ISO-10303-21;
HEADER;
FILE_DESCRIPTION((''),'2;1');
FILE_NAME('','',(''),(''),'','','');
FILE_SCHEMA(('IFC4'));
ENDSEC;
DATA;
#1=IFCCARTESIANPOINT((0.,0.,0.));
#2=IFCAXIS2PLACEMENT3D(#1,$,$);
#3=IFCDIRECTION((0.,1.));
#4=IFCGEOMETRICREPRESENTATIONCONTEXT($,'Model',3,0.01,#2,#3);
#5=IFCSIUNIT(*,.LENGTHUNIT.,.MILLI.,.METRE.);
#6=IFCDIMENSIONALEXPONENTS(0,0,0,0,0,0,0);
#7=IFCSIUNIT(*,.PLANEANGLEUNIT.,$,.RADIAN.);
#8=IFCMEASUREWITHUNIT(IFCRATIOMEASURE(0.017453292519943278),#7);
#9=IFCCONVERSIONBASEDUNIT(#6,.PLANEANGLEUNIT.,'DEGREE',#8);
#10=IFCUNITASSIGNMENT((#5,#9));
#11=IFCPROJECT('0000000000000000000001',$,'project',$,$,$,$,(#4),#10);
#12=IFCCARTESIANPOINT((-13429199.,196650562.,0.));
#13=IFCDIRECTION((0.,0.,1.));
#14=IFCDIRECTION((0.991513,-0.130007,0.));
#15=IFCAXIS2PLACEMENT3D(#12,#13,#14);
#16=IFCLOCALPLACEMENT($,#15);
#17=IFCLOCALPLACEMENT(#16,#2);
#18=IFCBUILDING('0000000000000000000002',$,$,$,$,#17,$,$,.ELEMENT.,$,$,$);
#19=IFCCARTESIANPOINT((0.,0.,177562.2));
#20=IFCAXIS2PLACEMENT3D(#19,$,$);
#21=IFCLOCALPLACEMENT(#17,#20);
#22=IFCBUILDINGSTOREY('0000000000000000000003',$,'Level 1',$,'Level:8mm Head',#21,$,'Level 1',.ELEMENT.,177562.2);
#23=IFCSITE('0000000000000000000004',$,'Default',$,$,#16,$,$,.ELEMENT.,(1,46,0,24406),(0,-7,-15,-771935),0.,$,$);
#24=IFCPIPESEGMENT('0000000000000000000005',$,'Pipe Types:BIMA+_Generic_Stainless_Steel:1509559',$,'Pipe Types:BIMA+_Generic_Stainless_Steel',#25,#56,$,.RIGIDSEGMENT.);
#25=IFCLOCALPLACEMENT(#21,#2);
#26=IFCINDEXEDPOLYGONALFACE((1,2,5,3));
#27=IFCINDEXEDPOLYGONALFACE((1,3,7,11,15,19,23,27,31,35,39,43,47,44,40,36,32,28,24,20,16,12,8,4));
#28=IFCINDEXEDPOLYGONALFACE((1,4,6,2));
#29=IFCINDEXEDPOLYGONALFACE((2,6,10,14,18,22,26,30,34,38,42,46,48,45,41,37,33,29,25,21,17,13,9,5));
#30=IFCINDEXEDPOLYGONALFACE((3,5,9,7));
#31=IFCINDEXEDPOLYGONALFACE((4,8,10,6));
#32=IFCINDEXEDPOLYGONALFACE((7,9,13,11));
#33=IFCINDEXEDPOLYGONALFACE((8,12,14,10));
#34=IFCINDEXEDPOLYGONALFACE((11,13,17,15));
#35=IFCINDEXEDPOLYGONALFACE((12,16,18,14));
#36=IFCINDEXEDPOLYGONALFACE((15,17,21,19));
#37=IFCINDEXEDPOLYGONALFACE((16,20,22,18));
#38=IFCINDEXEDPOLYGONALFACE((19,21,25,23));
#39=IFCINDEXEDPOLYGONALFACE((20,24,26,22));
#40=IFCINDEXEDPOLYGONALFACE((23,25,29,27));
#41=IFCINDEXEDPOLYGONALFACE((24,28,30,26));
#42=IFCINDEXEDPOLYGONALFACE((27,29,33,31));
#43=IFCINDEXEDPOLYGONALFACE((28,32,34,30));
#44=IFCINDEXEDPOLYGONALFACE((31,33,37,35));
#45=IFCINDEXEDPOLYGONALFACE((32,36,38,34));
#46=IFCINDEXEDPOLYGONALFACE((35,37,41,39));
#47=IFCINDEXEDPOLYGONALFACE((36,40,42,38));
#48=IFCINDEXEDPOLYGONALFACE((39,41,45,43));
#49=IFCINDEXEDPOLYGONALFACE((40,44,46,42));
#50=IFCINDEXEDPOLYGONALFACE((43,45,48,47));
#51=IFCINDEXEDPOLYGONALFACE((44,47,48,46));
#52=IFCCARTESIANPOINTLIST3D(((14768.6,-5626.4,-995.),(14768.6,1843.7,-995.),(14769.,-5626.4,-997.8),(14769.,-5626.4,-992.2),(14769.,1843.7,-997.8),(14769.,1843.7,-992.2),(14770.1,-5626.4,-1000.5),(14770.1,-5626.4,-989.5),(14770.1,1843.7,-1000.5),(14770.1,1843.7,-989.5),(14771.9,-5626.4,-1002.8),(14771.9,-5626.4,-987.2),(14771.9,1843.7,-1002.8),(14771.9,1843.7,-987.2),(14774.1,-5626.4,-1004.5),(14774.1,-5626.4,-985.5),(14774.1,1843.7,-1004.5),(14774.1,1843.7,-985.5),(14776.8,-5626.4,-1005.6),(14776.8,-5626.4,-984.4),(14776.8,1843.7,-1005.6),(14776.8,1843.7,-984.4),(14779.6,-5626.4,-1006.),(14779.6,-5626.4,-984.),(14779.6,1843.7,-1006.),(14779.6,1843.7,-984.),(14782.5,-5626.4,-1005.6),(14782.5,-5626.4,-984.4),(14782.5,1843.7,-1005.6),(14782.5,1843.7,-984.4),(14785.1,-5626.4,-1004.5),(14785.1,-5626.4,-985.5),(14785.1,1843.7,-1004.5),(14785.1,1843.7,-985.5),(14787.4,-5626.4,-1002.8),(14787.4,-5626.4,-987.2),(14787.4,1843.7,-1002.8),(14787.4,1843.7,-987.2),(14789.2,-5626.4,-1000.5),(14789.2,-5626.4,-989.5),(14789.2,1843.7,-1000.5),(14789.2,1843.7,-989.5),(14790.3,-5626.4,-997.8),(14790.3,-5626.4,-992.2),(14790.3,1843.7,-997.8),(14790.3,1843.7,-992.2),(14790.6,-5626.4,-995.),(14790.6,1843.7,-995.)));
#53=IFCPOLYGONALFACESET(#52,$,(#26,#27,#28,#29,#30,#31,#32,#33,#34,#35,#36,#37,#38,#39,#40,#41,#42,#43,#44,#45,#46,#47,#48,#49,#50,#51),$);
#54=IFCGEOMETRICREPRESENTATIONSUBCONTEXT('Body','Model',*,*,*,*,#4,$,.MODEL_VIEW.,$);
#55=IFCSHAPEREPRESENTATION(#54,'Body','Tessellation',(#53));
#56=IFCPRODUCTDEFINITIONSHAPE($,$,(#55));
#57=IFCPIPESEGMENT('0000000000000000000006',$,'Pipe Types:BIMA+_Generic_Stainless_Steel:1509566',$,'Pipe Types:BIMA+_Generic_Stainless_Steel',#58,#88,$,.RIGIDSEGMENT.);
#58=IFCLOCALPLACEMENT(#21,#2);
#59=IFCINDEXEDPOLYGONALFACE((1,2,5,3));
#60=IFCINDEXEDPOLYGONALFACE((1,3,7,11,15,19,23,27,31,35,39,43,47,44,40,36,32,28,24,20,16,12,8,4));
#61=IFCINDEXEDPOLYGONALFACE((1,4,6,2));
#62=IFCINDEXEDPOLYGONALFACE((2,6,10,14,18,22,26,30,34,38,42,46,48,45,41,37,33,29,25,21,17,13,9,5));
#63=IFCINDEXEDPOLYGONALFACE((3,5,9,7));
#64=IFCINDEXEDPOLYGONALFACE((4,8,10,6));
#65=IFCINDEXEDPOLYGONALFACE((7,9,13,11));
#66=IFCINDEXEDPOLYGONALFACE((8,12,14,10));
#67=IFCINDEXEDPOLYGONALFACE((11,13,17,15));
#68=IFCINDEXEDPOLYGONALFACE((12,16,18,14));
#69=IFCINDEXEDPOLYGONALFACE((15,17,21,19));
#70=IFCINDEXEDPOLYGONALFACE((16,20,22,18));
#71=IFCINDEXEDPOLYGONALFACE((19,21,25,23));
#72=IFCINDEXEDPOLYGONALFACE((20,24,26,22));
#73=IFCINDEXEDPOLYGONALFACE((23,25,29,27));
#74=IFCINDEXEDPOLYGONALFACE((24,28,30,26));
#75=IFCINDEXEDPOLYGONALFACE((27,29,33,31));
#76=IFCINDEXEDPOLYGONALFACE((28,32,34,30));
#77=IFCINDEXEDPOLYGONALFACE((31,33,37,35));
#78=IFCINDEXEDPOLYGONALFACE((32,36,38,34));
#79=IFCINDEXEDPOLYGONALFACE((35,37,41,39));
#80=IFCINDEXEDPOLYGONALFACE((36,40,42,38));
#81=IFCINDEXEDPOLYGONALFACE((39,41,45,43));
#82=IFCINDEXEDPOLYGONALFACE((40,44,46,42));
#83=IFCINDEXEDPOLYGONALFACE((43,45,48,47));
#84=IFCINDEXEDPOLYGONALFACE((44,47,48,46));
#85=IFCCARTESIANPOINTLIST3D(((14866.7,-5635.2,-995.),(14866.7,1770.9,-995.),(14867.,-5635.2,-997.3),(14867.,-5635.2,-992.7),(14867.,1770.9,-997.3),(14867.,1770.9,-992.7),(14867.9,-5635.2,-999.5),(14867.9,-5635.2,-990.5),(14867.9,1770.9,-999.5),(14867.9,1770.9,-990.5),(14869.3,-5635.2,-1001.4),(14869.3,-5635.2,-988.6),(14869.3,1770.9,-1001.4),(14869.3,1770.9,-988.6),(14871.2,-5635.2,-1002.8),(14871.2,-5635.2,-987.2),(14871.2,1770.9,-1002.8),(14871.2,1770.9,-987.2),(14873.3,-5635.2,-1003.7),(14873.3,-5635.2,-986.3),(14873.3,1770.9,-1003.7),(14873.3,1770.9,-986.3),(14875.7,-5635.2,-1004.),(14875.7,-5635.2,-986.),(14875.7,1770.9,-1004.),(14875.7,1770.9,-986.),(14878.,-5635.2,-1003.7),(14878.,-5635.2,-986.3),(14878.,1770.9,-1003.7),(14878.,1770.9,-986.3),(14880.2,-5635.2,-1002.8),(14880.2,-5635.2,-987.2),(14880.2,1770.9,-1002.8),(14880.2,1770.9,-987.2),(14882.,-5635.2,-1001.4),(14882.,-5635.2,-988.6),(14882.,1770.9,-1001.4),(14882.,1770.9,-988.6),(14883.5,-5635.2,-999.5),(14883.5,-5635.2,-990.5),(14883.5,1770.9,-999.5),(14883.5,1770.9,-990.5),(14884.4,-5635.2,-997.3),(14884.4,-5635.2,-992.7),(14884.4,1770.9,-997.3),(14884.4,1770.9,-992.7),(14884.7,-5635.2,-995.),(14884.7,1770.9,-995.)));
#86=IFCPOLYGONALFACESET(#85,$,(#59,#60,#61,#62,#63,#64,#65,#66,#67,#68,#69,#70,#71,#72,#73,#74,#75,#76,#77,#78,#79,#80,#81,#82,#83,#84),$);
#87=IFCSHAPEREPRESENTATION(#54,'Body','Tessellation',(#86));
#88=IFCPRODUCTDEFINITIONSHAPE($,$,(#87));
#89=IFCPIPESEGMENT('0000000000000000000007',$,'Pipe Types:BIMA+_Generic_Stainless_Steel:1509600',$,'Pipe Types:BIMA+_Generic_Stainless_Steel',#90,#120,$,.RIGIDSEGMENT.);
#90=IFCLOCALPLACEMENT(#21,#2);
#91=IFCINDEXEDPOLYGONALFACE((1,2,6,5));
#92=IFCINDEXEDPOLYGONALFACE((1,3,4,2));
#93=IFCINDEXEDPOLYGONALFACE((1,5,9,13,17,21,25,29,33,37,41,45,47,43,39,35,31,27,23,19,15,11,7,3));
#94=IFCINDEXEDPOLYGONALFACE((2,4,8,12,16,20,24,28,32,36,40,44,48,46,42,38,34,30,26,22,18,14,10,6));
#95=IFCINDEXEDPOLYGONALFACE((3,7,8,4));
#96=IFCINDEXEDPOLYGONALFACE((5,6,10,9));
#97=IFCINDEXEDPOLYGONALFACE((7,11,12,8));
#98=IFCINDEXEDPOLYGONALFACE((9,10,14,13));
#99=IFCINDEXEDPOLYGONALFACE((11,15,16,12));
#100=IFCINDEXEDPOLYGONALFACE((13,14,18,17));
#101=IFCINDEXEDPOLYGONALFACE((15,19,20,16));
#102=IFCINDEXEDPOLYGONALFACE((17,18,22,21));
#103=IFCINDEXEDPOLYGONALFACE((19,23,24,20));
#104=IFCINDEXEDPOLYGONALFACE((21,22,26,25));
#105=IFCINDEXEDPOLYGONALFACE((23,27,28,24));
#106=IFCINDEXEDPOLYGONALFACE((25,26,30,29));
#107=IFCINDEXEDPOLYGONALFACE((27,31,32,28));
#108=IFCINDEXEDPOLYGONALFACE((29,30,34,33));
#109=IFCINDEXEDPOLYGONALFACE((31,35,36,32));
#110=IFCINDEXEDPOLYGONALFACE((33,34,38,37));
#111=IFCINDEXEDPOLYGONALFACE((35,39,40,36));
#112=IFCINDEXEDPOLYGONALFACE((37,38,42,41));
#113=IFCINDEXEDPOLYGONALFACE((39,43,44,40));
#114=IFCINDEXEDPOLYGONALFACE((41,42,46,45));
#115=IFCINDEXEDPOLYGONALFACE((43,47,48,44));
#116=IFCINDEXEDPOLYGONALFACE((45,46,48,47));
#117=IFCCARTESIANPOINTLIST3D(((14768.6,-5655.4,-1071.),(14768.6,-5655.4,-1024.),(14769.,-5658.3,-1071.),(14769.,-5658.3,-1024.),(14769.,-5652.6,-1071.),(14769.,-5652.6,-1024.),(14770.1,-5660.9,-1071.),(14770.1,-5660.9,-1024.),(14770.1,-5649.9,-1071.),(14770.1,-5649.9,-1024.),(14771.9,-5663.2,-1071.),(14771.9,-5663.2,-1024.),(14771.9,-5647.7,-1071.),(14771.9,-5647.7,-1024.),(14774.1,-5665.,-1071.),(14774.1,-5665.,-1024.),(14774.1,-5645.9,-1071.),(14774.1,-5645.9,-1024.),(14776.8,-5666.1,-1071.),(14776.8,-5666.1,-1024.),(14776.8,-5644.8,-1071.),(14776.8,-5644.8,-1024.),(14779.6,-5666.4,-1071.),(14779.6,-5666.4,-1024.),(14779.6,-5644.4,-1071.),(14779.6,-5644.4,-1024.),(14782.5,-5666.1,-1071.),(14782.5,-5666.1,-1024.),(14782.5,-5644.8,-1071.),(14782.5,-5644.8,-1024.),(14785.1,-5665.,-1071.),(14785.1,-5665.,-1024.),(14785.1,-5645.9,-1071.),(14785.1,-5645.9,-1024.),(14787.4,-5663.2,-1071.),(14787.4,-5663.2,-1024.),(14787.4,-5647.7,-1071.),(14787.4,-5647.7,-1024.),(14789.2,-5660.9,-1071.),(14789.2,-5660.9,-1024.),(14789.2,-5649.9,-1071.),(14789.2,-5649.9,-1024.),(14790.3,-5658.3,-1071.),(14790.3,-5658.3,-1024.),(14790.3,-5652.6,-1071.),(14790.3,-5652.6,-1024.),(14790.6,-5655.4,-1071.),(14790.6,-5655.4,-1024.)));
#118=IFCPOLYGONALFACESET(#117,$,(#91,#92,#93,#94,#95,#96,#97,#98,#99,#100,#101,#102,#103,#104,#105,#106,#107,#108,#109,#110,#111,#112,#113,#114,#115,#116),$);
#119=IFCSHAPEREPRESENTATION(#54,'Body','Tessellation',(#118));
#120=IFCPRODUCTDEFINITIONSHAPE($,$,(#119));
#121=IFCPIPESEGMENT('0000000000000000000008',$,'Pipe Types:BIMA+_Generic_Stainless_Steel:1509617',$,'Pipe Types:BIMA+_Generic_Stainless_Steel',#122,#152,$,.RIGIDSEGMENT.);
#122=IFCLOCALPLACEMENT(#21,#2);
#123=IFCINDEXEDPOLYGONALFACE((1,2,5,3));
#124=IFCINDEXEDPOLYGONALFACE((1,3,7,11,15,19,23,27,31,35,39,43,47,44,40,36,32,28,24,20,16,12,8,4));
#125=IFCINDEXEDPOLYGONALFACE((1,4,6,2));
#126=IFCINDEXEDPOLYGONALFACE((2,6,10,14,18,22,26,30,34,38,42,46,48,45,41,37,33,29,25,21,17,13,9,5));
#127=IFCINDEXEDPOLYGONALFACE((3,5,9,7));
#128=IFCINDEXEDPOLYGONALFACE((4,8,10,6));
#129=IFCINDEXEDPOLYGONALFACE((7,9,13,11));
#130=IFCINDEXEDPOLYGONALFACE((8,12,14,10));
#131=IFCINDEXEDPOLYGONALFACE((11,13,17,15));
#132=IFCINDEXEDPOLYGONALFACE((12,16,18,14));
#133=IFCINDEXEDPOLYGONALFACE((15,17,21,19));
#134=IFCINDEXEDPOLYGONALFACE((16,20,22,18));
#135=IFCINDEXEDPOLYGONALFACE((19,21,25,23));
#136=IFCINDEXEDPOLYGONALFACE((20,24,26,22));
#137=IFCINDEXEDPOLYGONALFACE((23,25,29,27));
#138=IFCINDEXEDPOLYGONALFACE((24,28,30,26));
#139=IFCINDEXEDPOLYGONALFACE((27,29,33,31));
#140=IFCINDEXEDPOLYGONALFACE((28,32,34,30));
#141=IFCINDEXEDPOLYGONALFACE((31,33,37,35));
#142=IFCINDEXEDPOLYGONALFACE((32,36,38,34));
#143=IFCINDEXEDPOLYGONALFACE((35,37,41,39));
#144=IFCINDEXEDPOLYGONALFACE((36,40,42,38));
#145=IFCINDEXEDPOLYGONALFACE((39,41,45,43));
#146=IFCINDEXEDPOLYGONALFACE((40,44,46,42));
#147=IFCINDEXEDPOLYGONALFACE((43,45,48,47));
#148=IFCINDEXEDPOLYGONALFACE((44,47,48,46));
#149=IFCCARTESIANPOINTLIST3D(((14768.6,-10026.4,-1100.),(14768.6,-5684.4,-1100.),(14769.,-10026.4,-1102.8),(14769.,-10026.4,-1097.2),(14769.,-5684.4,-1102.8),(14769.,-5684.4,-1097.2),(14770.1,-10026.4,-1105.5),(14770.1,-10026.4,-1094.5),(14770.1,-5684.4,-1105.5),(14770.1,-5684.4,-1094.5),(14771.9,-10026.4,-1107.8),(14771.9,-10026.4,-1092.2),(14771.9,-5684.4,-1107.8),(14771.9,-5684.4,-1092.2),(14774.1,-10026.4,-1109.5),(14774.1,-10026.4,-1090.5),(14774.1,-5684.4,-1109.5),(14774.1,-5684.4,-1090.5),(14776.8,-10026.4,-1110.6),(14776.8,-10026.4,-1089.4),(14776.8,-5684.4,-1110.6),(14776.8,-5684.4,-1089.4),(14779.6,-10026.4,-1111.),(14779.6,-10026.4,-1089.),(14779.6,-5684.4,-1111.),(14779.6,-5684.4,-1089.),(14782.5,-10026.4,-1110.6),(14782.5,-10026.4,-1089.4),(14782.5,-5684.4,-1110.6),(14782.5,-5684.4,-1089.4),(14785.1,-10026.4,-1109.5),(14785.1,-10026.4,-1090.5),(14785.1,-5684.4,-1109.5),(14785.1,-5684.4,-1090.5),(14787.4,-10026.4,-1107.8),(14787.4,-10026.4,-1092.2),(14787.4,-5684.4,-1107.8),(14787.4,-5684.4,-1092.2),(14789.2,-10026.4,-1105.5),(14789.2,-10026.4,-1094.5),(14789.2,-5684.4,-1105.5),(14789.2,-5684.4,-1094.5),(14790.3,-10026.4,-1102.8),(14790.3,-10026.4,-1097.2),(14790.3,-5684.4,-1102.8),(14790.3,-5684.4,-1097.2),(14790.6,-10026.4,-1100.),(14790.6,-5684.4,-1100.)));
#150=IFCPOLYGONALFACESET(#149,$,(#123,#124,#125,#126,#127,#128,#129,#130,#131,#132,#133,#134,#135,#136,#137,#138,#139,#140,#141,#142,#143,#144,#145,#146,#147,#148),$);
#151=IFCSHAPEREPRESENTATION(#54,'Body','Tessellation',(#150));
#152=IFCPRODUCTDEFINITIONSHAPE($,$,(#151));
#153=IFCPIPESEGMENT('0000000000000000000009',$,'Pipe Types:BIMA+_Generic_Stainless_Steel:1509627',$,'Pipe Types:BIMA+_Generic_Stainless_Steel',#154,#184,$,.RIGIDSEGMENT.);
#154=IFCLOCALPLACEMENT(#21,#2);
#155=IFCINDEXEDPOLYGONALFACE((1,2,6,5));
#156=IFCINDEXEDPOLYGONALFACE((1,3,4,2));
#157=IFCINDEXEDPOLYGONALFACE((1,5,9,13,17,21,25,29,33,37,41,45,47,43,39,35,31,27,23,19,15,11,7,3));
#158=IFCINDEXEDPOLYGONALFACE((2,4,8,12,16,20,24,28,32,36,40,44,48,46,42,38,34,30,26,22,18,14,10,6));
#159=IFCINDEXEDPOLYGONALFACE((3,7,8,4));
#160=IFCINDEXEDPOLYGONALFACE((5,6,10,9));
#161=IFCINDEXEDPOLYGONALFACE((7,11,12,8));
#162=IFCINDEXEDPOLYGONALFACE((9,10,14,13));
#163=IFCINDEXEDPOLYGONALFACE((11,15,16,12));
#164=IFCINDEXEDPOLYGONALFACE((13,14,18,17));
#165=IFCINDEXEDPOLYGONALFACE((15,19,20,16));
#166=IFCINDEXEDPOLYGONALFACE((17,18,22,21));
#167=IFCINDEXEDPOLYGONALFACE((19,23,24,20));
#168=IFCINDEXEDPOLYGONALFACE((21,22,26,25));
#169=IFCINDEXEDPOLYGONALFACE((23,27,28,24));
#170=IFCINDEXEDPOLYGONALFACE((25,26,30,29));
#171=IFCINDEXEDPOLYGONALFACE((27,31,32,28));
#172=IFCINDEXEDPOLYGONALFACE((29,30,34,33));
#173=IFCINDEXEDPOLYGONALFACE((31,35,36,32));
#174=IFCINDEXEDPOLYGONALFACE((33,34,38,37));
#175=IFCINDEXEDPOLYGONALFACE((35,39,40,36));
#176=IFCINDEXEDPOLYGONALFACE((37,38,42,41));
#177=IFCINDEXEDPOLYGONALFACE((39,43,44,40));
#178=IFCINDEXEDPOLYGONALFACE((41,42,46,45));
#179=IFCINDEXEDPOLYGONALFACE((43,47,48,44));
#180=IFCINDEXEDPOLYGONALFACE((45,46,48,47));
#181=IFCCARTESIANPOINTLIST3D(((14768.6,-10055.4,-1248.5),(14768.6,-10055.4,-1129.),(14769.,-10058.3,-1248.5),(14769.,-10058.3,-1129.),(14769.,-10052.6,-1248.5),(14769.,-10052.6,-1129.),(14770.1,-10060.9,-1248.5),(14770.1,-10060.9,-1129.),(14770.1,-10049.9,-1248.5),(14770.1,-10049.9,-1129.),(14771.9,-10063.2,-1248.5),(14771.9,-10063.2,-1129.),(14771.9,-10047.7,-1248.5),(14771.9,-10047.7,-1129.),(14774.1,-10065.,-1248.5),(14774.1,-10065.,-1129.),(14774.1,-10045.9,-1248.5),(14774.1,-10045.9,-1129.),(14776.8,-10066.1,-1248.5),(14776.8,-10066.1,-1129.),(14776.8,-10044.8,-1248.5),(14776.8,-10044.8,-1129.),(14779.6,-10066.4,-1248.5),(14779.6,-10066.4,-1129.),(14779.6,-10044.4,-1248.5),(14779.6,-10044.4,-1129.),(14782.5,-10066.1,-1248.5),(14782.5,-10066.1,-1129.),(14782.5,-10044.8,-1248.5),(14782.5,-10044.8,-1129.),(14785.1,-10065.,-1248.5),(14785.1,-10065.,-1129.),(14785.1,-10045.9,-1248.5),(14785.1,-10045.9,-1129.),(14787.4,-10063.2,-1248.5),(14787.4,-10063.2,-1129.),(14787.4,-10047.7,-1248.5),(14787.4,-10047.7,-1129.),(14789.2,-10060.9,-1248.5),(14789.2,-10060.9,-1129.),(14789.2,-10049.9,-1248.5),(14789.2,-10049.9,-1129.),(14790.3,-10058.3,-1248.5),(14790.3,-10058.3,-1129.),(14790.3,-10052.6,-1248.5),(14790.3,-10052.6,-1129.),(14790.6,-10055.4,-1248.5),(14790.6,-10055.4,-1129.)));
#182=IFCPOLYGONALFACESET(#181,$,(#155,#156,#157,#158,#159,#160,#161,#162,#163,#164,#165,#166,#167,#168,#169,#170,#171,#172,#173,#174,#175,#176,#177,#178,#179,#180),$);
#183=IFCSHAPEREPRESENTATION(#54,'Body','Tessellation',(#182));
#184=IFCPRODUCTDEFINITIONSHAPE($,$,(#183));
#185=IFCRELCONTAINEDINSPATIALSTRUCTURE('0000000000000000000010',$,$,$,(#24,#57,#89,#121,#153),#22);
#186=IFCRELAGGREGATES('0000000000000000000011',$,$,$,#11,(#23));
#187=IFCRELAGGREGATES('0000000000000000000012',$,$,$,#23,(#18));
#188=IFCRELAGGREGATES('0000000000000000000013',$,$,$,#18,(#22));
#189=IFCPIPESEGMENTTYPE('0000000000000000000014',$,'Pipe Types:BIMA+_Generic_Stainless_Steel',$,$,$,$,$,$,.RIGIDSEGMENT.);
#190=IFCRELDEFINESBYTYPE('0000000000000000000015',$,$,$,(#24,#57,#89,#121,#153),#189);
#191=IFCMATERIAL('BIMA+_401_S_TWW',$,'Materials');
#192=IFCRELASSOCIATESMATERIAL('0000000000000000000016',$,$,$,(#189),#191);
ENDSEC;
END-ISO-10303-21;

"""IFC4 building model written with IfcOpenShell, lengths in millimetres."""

from ifc_helpers import new_model, entity, si_unit, converted_unit, direction, frame, origin, place, context, subcontext, project, spatial, arc, indexed_curve, outline, extrude, material, type_object, element, save


model = new_model("IFC4")

# Units and contexts
model_context = context("Model", 3, precision=0.01, world=origin(), true_north=direction((0.0, 1.0)))
body_context = subcontext(model_context, "Body", "Model", "MODEL_VIEW")
ifc_project = project(units=[si_unit("LENGTHUNIT", "METRE", prefix="MILLI"), converted_unit("PLANEANGLEUNIT", "DEGREE", entity("IfcRatioMeasure", 0.017453292519943278), si_unit("PLANEANGLEUNIT", "RADIAN"), dimensions=[0, 0, 0, 0, 0, 0, 0])], contexts=[model_context])

# Site, building, storey
site_placement = place(None, frame((-13429199.0, 196650562.0, 0.0), z_axis=(0.0, 0.0, 1.0), x_axis=(0.991513, -0.130007, 0.0)))
site = spatial("IfcSite", under=ifc_project, at=site_placement, Name="Default", CompositionType="ELEMENT", RefLatitude=(1, 46, 0, 24406), RefLongitude=(0, -7, -15, -771935), RefElevation=0.0)
building_placement = place(site_placement, origin())
building = spatial("IfcBuilding", under=site, at=building_placement, CompositionType="ELEMENT")
storey_placement = place(building_placement, frame((0.0, 0.0, 177562.2)))
storey = spatial("IfcBuildingStorey", under=building, at=storey_placement, Name="Level 1", ObjectType="Level:8mm Head", LongName="Level 1", CompositionType="ELEMENT", Elevation=177562.2)

# Pipe segments
ifc_material_1 = material(Name="BIMA+_401_S_TWW", Category="Materials")
pipe_segment_type_1 = type_object("IfcPipeSegmentType", Name="Pipe Types:BIMA+_Generic_Stainless_Steel", PredefinedType="RIGIDSEGMENT", material=ifc_material_1)
pipe_segment_1_placement = place(storey_placement, frame((14767.0, -5626.4, -1007.6)))
element("IfcPipeSegment", 1, at=pipe_segment_1_placement, inside=storey, type_object=pipe_segment_type_1, Name="Pipe Types:BIMA+_Generic_Stainless_Steel:1509559", ObjectType="Pipe Types:BIMA+_Generic_Stainless_Steel", PredefinedType="RIGIDSEGMENT", context=body_context, shape_type="SweptSolid", body=[
    extrude(outline(indexed_curve([(11.0, 0.0), (7.8, 7.8), (0.0, 11.0), (-7.8, 7.8), (-11.0, 0.0), (-7.8, -7.8), (0.0, -11.0), (7.8, -7.8)], segments=[arc(1, 2, 3), arc(3, 4, 5), arc(5, 6, 7), arc(7, 8, 1)], self_intersect=False)), frame((12.6, 0.0, 12.6), z_axis=(0.0, 1.0, 0.0), x_axis=(-1.0, 0.0, 0.0)), (0.0, 0.0, 1.0), 7470.2),
])
pipe_segment_2_placement = place(storey_placement, frame((14865.1, -5635.2, -1005.6)))
element("IfcPipeSegment", 2, at=pipe_segment_2_placement, inside=storey, type_object=pipe_segment_type_1, Name="Pipe Types:BIMA+_Generic_Stainless_Steel:1509566", ObjectType="Pipe Types:BIMA+_Generic_Stainless_Steel", PredefinedType="RIGIDSEGMENT", context=body_context, shape_type="SweptSolid", body=[
    extrude(outline(indexed_curve([(9.0, 0.0), (6.4, 6.4), (0.0, 9.0), (-6.4, 6.4), (-9.0, 0.0), (-6.4, -6.4), (0.0, -9.0), (6.4, -6.4)], segments=[arc(1, 2, 3), arc(3, 4, 5), arc(5, 6, 7), arc(7, 8, 1)], self_intersect=False)), frame((10.6, 0.0, 10.6), z_axis=(0.0, 1.0, 0.0), x_axis=(-1.0, 0.0, 0.0)), (0.0, 0.0, 1.0), 7406.0),
])
pipe_segment_3_placement = place(storey_placement, frame((14767.0, -5668.0, -1024.0)))
element("IfcPipeSegment", 3, at=pipe_segment_3_placement, inside=storey, type_object=pipe_segment_type_1, Name="Pipe Types:BIMA+_Generic_Stainless_Steel:1509600", ObjectType="Pipe Types:BIMA+_Generic_Stainless_Steel", PredefinedType="RIGIDSEGMENT", context=body_context, shape_type="SweptSolid", body=[
    extrude(outline(indexed_curve([(11.0, 0.0), (7.8, 7.8), (0.0, 11.0), (-7.8, 7.8), (-11.0, 0.0), (-7.8, -7.8), (0.0, -11.0), (7.8, -7.8)], segments=[arc(1, 2, 3), arc(3, 4, 5), arc(5, 6, 7), arc(7, 8, 1)], self_intersect=False)), frame((12.6, 12.6, -47.0)), (0.0, 0.0, 1.0), 47.0),
])
pipe_segment_4_placement = place(storey_placement, frame((14767.0, -10026.4, -1112.6)))
element("IfcPipeSegment", 4, at=pipe_segment_4_placement, inside=storey, type_object=pipe_segment_type_1, Name="Pipe Types:BIMA+_Generic_Stainless_Steel:1509617", ObjectType="Pipe Types:BIMA+_Generic_Stainless_Steel", PredefinedType="RIGIDSEGMENT", context=body_context, shape_type="SweptSolid", body=[
    extrude(outline(indexed_curve([(11.0, 0.0), (7.8, 7.8), (0.0, 11.0), (-7.8, 7.8), (-11.0, 0.0), (-7.8, -7.8), (0.0, -11.0), (7.8, -7.8)], segments=[arc(1, 2, 3), arc(3, 4, 5), arc(5, 6, 7), arc(7, 8, 1)], self_intersect=False)), frame((12.6, 0.0, 12.6), z_axis=(0.0, 1.0, 0.0), x_axis=(-1.0, 0.0, 0.0)), (0.0, 0.0, 1.0), 4342.0),
])
pipe_segment_5_placement = place(storey_placement, frame((14767.0, -10068.0, -1129.0)))
element("IfcPipeSegment", 5, at=pipe_segment_5_placement, inside=storey, type_object=pipe_segment_type_1, Name="Pipe Types:BIMA+_Generic_Stainless_Steel:1509627", ObjectType="Pipe Types:BIMA+_Generic_Stainless_Steel", PredefinedType="RIGIDSEGMENT", context=body_context, shape_type="SweptSolid", body=[
    extrude(outline(indexed_curve([(11.0, 0.0), (7.8, 7.8), (0.0, 11.0), (-7.8, 7.8), (-11.0, 0.0), (-7.8, -7.8), (0.0, -11.0), (7.8, -7.8)], segments=[arc(1, 2, 3), arc(3, 4, 5), arc(5, 6, 7), arc(7, 8, 1)], self_intersect=False)), frame((12.6, 12.6, -119.5)), (0.0, 0.0, 1.0), 119.5),
])

save(model, "model.ifc")
